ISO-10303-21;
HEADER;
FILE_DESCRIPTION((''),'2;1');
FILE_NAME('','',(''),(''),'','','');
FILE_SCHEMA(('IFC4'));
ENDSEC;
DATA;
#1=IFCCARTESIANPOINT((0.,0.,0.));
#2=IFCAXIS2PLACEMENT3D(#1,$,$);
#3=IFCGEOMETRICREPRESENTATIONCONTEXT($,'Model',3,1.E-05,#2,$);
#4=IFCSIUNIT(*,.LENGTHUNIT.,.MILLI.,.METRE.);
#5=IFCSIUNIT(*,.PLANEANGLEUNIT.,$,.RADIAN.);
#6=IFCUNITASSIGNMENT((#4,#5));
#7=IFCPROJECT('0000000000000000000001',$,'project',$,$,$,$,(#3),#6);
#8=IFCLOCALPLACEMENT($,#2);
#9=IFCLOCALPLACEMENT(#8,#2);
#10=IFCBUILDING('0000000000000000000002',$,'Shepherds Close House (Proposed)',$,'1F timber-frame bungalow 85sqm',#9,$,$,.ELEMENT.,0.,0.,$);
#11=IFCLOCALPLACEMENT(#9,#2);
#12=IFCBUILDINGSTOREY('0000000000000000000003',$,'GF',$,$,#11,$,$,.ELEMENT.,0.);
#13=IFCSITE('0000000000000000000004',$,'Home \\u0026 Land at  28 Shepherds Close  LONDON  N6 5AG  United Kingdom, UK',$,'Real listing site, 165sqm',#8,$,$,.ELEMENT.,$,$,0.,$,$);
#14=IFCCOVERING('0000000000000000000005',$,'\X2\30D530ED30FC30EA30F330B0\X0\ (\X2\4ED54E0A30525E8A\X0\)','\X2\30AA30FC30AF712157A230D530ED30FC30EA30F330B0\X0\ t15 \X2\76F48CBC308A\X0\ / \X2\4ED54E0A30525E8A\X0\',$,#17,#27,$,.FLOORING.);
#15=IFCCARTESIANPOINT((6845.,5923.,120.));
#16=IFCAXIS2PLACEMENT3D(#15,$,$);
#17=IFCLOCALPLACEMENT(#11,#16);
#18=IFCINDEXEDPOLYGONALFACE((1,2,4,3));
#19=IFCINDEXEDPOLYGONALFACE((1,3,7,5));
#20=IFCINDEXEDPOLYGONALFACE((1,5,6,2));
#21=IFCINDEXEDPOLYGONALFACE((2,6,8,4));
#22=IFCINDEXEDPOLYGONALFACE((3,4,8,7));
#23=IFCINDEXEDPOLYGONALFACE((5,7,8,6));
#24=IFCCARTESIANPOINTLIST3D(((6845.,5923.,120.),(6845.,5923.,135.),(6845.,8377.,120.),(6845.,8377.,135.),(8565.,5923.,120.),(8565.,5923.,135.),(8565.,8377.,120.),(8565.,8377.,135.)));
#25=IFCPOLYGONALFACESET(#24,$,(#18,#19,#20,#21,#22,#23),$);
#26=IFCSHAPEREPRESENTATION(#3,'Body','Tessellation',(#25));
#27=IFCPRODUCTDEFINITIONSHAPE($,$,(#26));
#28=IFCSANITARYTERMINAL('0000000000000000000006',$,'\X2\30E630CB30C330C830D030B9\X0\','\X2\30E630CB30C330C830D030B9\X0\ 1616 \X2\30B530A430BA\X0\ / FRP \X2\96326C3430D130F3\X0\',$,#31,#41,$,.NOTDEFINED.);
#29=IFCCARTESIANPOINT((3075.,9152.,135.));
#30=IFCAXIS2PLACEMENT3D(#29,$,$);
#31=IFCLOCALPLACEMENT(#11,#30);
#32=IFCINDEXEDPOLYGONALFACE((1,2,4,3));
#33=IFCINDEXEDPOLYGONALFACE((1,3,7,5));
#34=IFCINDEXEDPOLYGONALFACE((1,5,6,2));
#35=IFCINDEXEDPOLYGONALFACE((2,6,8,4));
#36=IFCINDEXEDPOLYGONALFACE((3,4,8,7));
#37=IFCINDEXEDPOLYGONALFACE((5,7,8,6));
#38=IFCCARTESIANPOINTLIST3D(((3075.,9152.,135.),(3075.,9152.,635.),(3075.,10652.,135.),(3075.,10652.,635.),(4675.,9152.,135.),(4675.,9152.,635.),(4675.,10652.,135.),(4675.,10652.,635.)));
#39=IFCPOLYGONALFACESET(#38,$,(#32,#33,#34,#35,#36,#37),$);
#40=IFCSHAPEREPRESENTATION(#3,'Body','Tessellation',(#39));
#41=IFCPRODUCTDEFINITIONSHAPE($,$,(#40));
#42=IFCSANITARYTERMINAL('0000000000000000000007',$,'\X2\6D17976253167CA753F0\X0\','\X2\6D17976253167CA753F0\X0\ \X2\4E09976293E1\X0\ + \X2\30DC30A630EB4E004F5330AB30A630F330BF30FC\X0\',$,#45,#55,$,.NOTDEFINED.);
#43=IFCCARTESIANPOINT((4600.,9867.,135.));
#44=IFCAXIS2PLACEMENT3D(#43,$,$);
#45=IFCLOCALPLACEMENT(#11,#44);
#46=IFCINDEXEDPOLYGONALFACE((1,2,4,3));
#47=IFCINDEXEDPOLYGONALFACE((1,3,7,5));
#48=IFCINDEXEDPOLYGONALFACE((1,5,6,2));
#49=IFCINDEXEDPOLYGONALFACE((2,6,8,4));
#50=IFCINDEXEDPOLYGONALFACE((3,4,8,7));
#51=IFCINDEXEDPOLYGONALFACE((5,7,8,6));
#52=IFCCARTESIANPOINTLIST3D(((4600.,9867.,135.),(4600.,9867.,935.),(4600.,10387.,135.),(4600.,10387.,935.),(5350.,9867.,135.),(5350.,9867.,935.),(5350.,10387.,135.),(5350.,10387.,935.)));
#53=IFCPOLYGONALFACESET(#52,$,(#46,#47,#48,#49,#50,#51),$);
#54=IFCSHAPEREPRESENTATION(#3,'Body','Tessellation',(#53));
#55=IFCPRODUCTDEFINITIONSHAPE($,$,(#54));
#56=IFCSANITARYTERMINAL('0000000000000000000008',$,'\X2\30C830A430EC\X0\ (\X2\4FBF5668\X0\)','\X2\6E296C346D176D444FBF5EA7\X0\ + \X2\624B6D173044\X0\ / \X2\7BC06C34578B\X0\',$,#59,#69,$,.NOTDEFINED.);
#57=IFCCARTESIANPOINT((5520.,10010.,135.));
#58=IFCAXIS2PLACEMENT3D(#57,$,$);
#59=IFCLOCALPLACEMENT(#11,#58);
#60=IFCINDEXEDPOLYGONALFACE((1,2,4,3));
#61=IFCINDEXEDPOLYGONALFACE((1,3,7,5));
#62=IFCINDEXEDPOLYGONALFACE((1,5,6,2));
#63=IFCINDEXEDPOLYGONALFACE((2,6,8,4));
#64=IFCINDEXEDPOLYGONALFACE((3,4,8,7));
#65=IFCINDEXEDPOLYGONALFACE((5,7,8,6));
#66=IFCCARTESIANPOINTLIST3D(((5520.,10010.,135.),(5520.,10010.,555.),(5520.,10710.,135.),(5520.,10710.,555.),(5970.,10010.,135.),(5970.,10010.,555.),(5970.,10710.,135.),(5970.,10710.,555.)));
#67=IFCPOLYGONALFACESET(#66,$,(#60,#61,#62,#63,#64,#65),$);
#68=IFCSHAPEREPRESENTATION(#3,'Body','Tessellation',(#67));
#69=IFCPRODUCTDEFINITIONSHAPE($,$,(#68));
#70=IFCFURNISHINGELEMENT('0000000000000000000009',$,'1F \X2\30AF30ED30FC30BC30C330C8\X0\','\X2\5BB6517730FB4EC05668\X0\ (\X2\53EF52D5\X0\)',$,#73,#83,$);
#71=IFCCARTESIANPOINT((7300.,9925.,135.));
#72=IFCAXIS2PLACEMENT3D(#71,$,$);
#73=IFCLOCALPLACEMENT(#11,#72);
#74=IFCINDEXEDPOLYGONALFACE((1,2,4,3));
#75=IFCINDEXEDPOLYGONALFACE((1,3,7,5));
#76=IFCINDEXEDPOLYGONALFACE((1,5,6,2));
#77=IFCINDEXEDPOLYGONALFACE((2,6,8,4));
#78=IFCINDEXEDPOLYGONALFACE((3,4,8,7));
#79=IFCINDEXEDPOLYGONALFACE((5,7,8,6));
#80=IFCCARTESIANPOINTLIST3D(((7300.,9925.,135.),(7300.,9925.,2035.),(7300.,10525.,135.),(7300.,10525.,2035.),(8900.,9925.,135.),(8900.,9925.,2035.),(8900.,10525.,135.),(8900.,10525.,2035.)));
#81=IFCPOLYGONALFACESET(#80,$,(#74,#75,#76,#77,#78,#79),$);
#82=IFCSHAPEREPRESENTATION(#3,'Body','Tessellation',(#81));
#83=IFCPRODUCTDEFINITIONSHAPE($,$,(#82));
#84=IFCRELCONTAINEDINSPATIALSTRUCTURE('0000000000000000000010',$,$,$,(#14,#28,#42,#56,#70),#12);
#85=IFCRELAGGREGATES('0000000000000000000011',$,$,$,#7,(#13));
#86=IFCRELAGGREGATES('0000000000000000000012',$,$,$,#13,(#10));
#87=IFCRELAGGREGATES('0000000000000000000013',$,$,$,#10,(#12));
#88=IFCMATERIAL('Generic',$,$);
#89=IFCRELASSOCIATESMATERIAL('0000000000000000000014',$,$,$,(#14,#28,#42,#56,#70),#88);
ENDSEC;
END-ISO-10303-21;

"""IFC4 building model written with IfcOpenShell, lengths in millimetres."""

from ifc_helpers import new_model, si_unit, frame, frame_2d, origin, place, context, project, spatial, rectangle, extrude, material, element, save


model = new_model("IFC4")

# Units and contexts
model_context = context("Model", 3, precision=1e-05, world=origin())
ifc_project = project(units=[si_unit("LENGTHUNIT", "METRE", prefix="MILLI"), si_unit("PLANEANGLEUNIT", "RADIAN")], contexts=[model_context])

# Site, building, storey
site_placement = place(None, origin())
site = spatial("IfcSite", under=ifc_project, at=site_placement, Name="Home \\u0026 Land at  28 Shepherds Close  LONDON  N6 5AG  United Kingdom, UK", ObjectType="Real listing site, 165sqm", CompositionType="ELEMENT", RefElevation=0.0)
building_placement = place(site_placement, origin())
building = spatial("IfcBuilding", under=site, at=building_placement, Name="Shepherds Close House (Proposed)", ObjectType="1F timber-frame bungalow 85sqm", CompositionType="ELEMENT", ElevationOfRefHeight=0.0, ElevationOfTerrain=0.0)
storey_placement = place(building_placement, origin())
storey = spatial("IfcBuildingStorey", under=building, at=storey_placement, Name="GF", CompositionType="ELEMENT", Elevation=0.0)

# Covering
ifc_material_1 = material(Name="Generic")
covering_1_placement = place(storey_placement, frame((6845.0, 5923.0, 120.0)))
element("IfcCovering", 1, at=covering_1_placement, inside=storey, material=ifc_material_1, Name="フローリング (仕上げ床)", Description="オーク無垢フローリング t15 直貼り / 仕上げ床", PredefinedType="FLOORING", context=model_context, shape_type="SweptSolid", body=[
    extrude(rectangle(XDim=1720.0, YDim=2454.0, at=frame_2d((860.0, 1227.0))), frame((6845.0, 5923.0, 120.0)), (0.0, 0.0, 1.0), 15.0),
])

# Sanitary terminals
sanitary_terminal_1_placement = place(storey_placement, frame((3075.0, 9152.0, 135.0)))
element("IfcSanitaryTerminal", 2, at=sanitary_terminal_1_placement, inside=storey, material=ifc_material_1, Name="ユニットバス", Description="ユニットバス 1616 サイズ / FRP 防水パン", PredefinedType="NOTDEFINED", context=model_context, shape_type="SweptSolid", body=[
    extrude(rectangle(XDim=1600.0, YDim=1500.0, at=frame_2d((800.0, 750.0))), frame((3075.0, 9152.0, 135.0)), (0.0, 0.0, 1.0), 500.0),
])
sanitary_terminal_2_placement = place(storey_placement, frame((4600.0, 9867.0, 135.0)))
element("IfcSanitaryTerminal", 3, at=sanitary_terminal_2_placement, inside=storey, material=ifc_material_1, Name="洗面化粧台", Description="洗面化粧台 三面鏡 + ボウル一体カウンター", PredefinedType="NOTDEFINED", context=model_context, shape_type="SweptSolid", body=[
    extrude(rectangle(XDim=750.0, YDim=520.0, at=frame_2d((375.0, 260.0))), frame((4600.0, 9867.0, 135.0)), (0.0, 0.0, 1.0), 800.0),
])
sanitary_terminal_3_placement = place(storey_placement, frame((5520.0, 10010.0, 135.0)))
element("IfcSanitaryTerminal", 4, at=sanitary_terminal_3_placement, inside=storey, material=ifc_material_1, Name="トイレ (便器)", Description="温水洗浄便座 + 手洗い / 節水型", PredefinedType="NOTDEFINED", context=model_context, shape_type="SweptSolid", body=[
    extrude(rectangle(XDim=450.0, YDim=700.0, at=frame_2d((225.0, 350.0))), frame((5520.0, 10010.0, 135.0)), (0.0, 0.0, 1.0), 420.0),
])

# Furnishing element
furnishing_placement = place(storey_placement, frame((7300.0, 9925.0, 135.0)))
element("IfcFurnishingElement", 5, at=furnishing_placement, inside=storey, material=ifc_material_1, Name="1F クローゼット", Description="家具・什器 (可動)", context=model_context, shape_type="SweptSolid", body=[
    extrude(rectangle(XDim=1600.0, YDim=600.0, at=frame_2d((800.0, 300.0))), frame((7300.0, 9925.0, 135.0)), (0.0, 0.0, 1.0), 1900.0),
])

save(model, "model.ifc")
